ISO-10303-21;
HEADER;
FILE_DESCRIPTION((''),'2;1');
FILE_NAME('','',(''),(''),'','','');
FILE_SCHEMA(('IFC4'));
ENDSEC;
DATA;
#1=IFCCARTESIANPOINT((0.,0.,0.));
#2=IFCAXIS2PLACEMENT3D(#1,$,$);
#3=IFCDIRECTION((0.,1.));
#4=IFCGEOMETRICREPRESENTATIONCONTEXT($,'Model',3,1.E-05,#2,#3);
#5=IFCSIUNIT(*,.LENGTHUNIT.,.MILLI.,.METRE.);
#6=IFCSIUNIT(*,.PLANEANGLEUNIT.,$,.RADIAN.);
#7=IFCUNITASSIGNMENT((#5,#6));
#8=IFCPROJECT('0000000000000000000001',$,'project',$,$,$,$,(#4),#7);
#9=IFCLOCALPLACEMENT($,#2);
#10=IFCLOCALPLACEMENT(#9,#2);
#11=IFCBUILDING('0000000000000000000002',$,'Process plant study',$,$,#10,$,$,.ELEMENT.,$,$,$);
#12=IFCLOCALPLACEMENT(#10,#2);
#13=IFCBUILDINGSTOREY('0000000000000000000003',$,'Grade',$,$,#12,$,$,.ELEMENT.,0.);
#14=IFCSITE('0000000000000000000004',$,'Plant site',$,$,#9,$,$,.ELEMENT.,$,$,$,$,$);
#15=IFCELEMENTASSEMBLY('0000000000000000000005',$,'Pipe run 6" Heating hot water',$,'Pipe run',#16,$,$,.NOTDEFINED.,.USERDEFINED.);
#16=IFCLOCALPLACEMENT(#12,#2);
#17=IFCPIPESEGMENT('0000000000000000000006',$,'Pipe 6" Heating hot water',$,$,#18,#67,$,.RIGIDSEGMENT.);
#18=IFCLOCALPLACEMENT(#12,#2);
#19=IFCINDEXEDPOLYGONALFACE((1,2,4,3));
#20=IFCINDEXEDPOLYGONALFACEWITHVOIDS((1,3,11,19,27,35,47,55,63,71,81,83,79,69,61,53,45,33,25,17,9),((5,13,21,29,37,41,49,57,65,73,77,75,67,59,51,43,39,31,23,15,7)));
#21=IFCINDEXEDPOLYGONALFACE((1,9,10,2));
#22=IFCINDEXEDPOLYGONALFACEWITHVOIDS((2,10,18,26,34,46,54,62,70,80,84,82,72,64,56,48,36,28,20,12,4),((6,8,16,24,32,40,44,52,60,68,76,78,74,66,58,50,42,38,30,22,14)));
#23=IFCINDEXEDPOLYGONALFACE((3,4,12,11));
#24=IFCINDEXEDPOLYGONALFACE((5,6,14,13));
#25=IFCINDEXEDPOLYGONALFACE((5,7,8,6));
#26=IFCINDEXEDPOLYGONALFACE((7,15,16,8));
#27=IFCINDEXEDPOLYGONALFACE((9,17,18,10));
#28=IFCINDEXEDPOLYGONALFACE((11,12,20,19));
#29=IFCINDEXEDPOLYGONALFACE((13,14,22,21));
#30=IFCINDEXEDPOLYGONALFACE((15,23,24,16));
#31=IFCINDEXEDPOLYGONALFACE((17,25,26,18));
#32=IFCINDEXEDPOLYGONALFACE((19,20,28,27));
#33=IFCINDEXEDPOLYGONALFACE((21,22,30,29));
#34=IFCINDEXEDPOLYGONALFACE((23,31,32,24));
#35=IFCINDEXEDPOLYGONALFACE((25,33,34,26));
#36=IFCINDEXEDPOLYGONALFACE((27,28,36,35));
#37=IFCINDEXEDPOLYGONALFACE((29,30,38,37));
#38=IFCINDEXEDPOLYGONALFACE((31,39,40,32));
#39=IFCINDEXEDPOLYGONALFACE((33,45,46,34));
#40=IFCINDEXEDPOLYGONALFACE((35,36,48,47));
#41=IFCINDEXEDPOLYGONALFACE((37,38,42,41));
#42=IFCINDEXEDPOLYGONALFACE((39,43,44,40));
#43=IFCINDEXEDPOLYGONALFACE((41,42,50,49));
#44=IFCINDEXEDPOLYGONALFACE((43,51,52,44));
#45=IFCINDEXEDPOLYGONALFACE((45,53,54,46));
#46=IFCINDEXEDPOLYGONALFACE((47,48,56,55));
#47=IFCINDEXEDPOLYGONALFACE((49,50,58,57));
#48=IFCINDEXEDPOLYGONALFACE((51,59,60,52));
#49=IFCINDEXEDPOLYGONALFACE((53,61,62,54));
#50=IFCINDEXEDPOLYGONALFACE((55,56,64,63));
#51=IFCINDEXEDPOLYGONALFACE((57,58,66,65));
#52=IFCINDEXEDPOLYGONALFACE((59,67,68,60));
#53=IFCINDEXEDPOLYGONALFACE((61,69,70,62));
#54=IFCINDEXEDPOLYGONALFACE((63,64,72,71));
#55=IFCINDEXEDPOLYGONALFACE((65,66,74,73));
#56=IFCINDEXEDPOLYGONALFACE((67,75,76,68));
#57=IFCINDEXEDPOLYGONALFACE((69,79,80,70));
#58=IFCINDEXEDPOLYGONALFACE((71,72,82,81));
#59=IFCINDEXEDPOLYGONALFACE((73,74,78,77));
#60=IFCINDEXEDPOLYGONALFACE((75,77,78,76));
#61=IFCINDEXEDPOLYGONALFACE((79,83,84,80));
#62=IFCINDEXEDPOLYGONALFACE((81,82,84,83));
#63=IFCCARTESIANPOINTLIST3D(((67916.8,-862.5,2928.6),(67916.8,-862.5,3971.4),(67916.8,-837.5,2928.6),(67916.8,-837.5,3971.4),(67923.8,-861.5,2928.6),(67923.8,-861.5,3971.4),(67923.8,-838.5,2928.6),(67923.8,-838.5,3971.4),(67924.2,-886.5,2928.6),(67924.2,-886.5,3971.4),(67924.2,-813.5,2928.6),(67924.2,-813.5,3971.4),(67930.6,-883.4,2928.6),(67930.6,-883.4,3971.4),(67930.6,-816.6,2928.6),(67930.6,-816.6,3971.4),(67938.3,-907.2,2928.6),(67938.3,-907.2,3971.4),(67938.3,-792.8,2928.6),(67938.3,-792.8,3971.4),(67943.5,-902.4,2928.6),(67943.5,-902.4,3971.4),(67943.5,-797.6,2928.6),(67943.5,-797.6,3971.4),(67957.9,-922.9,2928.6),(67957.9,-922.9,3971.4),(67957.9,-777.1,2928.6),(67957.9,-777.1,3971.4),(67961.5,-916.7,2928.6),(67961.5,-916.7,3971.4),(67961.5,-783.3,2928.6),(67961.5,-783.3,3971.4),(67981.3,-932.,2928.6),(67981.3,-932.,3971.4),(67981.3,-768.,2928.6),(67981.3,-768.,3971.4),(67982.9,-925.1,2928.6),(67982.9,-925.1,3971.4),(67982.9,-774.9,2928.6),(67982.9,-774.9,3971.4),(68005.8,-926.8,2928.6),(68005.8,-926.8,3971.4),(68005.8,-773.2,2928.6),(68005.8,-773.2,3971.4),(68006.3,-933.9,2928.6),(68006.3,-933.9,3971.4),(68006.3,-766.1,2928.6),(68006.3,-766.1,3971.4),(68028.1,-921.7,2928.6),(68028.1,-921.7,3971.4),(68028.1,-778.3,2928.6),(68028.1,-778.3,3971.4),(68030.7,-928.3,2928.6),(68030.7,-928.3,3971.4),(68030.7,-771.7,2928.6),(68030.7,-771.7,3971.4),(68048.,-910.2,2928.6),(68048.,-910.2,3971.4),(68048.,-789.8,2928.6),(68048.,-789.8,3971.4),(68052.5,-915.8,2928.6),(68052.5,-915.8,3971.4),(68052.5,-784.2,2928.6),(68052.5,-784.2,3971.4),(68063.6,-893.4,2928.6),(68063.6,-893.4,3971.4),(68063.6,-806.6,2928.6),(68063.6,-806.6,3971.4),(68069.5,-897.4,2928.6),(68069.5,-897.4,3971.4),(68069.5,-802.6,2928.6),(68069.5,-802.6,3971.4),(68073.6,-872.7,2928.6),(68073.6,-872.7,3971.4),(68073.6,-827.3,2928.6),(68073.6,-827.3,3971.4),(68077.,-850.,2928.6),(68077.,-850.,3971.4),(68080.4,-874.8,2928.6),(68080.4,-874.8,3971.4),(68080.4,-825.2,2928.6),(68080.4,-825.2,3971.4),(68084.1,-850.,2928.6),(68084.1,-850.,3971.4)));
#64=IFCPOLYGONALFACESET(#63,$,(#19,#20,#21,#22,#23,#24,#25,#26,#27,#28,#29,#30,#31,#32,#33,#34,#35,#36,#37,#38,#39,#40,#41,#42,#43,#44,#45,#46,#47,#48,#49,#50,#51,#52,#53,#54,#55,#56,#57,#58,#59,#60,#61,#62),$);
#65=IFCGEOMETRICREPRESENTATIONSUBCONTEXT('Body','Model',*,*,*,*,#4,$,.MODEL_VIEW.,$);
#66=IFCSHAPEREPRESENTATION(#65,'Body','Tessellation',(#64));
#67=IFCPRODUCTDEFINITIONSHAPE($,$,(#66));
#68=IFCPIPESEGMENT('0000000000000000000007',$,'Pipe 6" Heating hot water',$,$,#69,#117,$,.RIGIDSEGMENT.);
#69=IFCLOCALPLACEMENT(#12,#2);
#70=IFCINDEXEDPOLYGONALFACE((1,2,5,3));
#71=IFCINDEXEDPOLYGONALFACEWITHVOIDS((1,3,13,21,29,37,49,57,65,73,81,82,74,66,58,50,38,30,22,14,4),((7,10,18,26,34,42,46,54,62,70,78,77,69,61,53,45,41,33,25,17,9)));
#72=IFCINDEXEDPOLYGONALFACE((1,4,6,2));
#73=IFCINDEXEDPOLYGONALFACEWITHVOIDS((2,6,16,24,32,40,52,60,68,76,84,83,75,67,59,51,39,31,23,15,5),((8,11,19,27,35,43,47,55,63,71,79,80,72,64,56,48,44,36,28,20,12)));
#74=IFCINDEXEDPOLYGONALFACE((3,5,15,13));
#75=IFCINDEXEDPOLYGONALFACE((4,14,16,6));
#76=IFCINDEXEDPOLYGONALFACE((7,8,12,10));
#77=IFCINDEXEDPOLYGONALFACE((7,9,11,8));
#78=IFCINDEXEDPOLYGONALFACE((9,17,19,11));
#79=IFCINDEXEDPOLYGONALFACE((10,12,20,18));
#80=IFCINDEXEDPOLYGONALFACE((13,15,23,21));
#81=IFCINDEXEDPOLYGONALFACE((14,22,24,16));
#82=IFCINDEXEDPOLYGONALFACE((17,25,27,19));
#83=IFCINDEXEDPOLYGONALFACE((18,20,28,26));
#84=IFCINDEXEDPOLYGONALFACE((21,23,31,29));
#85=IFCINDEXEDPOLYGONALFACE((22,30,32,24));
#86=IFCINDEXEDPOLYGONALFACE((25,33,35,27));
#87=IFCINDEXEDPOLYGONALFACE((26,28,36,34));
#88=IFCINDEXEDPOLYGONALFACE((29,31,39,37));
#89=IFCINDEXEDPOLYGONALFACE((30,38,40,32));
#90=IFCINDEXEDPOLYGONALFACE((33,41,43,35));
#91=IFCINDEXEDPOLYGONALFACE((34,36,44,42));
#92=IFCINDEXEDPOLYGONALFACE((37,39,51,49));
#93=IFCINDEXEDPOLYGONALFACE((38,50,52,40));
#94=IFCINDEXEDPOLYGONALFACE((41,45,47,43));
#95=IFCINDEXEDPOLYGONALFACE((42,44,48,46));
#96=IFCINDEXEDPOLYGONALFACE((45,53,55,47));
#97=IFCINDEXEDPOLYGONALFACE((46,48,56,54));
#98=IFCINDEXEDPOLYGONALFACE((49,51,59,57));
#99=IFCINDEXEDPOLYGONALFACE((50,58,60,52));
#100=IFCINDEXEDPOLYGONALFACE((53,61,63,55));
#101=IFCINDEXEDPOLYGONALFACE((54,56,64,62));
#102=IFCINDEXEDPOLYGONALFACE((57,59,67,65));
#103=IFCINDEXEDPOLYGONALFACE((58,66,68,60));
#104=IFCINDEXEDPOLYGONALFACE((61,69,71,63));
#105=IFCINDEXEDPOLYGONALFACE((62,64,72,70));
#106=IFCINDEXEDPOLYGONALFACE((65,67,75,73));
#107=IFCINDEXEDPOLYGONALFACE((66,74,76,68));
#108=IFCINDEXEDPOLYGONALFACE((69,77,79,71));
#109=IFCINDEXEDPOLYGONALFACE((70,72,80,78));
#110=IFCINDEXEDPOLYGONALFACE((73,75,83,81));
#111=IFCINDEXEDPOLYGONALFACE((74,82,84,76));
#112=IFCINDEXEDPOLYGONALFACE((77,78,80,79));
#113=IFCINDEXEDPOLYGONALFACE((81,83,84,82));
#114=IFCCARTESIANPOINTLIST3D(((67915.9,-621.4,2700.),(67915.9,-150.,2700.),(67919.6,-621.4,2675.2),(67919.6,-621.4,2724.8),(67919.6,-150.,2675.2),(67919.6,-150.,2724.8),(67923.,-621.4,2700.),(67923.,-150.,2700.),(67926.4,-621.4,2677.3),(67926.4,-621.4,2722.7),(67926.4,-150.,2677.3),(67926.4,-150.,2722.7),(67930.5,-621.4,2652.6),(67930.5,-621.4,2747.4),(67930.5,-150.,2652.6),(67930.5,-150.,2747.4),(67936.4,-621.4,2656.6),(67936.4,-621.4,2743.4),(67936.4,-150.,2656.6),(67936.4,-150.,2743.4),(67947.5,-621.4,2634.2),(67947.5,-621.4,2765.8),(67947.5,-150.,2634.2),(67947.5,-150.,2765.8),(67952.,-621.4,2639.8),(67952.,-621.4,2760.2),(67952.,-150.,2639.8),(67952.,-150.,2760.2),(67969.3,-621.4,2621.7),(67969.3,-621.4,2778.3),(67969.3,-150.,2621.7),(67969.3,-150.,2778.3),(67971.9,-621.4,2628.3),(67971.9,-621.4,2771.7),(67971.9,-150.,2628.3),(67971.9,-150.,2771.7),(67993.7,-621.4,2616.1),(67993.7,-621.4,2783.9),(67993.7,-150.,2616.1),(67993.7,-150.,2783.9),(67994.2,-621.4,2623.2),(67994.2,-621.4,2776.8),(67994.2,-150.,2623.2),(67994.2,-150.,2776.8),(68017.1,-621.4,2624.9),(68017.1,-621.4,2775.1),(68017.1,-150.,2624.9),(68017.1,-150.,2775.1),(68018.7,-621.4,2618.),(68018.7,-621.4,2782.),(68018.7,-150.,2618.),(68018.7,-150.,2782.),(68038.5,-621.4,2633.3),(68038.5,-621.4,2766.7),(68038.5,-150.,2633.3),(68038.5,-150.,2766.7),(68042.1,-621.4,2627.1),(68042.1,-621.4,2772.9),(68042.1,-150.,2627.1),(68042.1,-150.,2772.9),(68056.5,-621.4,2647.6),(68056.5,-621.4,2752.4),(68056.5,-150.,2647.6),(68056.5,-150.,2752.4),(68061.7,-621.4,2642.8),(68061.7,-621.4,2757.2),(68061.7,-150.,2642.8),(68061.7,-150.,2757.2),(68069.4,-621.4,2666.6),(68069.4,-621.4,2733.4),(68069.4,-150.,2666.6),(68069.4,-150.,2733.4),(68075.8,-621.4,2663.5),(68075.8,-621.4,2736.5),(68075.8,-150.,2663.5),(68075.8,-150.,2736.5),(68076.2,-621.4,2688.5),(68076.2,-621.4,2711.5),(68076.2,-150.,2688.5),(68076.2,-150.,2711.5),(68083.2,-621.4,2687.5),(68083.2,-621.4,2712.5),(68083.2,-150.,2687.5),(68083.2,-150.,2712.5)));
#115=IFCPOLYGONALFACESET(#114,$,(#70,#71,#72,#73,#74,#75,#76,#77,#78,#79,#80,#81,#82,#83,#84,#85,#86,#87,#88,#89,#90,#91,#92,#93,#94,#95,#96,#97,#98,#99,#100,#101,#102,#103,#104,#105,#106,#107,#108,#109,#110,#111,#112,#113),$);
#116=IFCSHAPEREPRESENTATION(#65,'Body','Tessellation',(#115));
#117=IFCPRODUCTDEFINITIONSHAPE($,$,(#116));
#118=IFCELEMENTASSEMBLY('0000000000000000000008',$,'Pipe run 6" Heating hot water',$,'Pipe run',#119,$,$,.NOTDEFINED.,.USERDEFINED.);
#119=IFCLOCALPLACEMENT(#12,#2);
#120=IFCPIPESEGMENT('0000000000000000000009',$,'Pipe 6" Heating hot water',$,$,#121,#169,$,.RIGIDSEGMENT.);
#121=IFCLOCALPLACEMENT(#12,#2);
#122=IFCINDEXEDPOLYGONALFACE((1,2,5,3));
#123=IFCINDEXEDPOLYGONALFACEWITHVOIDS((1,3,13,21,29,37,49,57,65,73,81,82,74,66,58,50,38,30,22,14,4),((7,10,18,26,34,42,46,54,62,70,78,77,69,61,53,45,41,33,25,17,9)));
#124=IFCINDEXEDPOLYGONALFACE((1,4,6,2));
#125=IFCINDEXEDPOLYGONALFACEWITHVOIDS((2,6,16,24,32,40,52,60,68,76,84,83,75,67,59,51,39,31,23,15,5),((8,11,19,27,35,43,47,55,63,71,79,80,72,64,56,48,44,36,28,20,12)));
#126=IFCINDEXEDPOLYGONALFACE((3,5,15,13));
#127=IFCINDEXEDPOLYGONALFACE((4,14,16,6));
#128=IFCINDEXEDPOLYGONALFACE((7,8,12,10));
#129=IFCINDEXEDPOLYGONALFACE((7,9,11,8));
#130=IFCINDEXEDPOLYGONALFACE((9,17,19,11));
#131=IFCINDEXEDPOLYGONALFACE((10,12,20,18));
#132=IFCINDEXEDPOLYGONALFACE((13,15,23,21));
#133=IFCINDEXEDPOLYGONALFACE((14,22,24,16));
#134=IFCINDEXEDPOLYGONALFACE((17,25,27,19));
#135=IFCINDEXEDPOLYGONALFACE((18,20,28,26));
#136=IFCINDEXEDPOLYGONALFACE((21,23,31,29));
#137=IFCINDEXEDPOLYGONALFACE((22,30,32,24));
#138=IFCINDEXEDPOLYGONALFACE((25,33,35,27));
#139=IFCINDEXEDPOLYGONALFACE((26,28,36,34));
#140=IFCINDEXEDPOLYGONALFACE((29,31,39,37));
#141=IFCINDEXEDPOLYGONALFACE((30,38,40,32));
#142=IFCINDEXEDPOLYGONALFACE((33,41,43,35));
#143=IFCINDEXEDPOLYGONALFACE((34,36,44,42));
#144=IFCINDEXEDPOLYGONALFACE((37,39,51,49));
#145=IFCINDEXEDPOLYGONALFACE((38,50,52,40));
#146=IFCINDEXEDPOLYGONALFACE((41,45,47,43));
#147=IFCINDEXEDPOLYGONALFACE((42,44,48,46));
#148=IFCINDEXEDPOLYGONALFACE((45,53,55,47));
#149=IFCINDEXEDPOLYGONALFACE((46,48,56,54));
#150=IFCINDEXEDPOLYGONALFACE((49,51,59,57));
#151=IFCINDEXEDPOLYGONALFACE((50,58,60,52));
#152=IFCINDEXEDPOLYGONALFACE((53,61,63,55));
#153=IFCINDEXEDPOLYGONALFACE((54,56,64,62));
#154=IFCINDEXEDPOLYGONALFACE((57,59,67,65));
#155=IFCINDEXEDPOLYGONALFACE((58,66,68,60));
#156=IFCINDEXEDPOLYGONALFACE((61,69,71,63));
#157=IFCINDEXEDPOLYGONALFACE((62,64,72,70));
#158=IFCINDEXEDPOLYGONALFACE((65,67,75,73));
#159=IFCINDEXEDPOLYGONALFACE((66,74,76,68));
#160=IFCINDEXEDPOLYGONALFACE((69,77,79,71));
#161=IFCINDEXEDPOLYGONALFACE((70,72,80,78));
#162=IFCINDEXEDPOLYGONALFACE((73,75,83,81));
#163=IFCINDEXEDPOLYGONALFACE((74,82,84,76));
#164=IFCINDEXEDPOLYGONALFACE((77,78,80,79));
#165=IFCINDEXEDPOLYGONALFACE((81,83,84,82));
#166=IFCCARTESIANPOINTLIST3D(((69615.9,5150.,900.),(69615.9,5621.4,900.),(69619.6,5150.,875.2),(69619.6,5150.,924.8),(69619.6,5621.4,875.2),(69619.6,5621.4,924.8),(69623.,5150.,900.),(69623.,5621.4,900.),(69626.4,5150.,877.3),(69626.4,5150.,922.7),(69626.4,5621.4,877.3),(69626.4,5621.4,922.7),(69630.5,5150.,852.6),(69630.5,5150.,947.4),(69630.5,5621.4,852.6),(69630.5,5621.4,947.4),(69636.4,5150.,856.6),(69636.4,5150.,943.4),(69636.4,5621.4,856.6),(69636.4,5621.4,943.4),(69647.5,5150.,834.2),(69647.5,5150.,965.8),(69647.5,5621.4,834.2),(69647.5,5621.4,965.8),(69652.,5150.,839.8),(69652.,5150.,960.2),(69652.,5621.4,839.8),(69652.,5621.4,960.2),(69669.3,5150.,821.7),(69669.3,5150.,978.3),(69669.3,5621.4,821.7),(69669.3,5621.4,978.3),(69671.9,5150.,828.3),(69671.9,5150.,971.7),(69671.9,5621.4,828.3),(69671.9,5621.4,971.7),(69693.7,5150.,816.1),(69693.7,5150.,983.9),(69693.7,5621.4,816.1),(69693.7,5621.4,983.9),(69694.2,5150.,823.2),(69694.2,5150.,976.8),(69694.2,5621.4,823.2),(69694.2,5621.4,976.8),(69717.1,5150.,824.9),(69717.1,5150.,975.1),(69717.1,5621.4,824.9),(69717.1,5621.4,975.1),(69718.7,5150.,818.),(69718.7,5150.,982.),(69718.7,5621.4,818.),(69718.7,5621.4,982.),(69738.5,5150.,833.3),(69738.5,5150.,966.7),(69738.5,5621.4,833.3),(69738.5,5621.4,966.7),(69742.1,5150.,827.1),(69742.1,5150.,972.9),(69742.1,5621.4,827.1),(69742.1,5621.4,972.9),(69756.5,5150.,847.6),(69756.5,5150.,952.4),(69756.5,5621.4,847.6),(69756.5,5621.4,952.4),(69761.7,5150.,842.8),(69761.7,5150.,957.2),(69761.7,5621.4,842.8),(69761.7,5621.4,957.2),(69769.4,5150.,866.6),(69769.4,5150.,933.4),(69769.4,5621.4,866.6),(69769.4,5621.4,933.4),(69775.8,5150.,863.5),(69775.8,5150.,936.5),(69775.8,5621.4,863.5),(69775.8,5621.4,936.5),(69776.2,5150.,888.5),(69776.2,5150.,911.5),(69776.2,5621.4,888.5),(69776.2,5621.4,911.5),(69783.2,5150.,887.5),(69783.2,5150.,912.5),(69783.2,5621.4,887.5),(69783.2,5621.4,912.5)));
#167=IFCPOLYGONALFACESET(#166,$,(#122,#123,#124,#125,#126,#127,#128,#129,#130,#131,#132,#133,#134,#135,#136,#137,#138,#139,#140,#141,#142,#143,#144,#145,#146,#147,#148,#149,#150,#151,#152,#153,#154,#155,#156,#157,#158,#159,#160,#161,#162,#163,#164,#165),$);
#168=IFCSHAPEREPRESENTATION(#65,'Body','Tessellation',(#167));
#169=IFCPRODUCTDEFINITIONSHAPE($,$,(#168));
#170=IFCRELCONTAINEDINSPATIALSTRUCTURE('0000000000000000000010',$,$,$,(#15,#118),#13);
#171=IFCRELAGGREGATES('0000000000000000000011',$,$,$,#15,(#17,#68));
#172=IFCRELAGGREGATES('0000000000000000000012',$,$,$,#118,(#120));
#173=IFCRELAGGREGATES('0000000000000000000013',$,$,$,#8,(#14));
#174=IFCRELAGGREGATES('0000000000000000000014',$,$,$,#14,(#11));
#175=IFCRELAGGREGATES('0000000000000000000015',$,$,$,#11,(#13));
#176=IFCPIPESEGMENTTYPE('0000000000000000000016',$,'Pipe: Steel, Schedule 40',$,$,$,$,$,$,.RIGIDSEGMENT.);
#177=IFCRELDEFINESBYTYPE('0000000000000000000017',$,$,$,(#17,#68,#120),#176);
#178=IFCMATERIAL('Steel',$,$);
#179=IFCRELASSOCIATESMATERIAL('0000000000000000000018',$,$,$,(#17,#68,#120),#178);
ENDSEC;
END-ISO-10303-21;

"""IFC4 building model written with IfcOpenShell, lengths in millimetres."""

from ifc_helpers import new_model, si_unit, direction, frame, origin, origin_with_axes, origin_2d, place, context, subcontext, project, spatial, hollow_circle, extrude, material, type_object, element, aggregate, save


model = new_model("IFC4")

# Units and contexts
model_context = context("Model", 3, precision=1e-05, world=origin(), true_north=direction((0.0, 1.0)))
body_context = subcontext(model_context, "Body", "Model", "MODEL_VIEW")
ifc_project = project(units=[si_unit("LENGTHUNIT", "METRE", prefix="MILLI"), si_unit("PLANEANGLEUNIT", "RADIAN")], contexts=[model_context])

# Site, building, storey
site_placement = place(None, origin())
site = spatial("IfcSite", under=ifc_project, at=site_placement, Name="Plant site", CompositionType="ELEMENT")
building_placement = place(site_placement, origin())
building = spatial("IfcBuilding", under=site, at=building_placement, Name="Process plant study", CompositionType="ELEMENT")
storey_placement = place(building_placement, origin())
storey = spatial("IfcBuildingStorey", under=building, at=storey_placement, Name="Grade", CompositionType="ELEMENT", Elevation=0.0)

# Element assemblies, pipe segments
ifc_material = material(Name="Steel")
pipe_segment_type = type_object("IfcPipeSegmentType", Name="Pipe: Steel, Schedule 40", PredefinedType="RIGIDSEGMENT")
assembly_1_placement = place(storey_placement, origin_with_axes())
assembly_1 = element("IfcElementAssembly", 1, at=assembly_1_placement, inside=storey, Name="Pipe run 6\" Heating hot water", ObjectType="Pipe run", AssemblyPlace="NOTDEFINED", PredefinedType="USERDEFINED")
pipe_segment_1_placement = place(storey_placement, origin_with_axes())
pipe_segment_1 = element("IfcPipeSegment", 2, at=pipe_segment_1_placement, type_object=pipe_segment_type, material=ifc_material, Name="Pipe 6\" Heating hot water", PredefinedType="RIGIDSEGMENT", context=body_context, shape_type="SweptSolid", body=[
    extrude(hollow_circle(Radius=84.1, WallThickness=7.1, at=origin_2d()), frame((68000.0, -850.0, 3971.4), z_axis=(0.0, 0.0, -1.0), x_axis=(1.0, 0.0, 0.0)), (0.0, 0.0, 1.0), 1042.8),
])
pipe_segment_2_placement = place(storey_placement, origin_with_axes())
pipe_segment_2 = element("IfcPipeSegment", 3, at=pipe_segment_2_placement, type_object=pipe_segment_type, material=ifc_material, Name="Pipe 6\" Heating hot water", PredefinedType="RIGIDSEGMENT", context=body_context, shape_type="SweptSolid", body=[
    extrude(hollow_circle(Radius=84.1, WallThickness=7.1, at=origin_2d()), frame((68000.0, -621.4, 2700.0), z_axis=(0.0, 1.0, 0.0), x_axis=(-1.0, 0.0, 0.0)), (0.0, 0.0, 1.0), 471.4),
])
assembly_2_placement = place(storey_placement, origin_with_axes())
assembly_2 = element("IfcElementAssembly", 4, at=assembly_2_placement, inside=storey, Name="Pipe run 6\" Heating hot water", ObjectType="Pipe run", AssemblyPlace="NOTDEFINED", PredefinedType="USERDEFINED")
pipe_segment_3_placement = place(storey_placement, origin_with_axes())
pipe_segment_3 = element("IfcPipeSegment", 5, at=pipe_segment_3_placement, type_object=pipe_segment_type, material=ifc_material, Name="Pipe 6\" Heating hot water", PredefinedType="RIGIDSEGMENT", context=body_context, shape_type="SweptSolid", body=[
    extrude(hollow_circle(Radius=84.1, WallThickness=7.1, at=origin_2d()), frame((69700.0, 5150.0, 900.0), z_axis=(0.0, 1.0, 0.0), x_axis=(-1.0, 0.0, 0.0)), (0.0, 0.0, 1.0), 471.4),
])

aggregate(assembly_1, [pipe_segment_1, pipe_segment_2])
aggregate(assembly_2, [pipe_segment_3])

save(model, "model.ifc")
